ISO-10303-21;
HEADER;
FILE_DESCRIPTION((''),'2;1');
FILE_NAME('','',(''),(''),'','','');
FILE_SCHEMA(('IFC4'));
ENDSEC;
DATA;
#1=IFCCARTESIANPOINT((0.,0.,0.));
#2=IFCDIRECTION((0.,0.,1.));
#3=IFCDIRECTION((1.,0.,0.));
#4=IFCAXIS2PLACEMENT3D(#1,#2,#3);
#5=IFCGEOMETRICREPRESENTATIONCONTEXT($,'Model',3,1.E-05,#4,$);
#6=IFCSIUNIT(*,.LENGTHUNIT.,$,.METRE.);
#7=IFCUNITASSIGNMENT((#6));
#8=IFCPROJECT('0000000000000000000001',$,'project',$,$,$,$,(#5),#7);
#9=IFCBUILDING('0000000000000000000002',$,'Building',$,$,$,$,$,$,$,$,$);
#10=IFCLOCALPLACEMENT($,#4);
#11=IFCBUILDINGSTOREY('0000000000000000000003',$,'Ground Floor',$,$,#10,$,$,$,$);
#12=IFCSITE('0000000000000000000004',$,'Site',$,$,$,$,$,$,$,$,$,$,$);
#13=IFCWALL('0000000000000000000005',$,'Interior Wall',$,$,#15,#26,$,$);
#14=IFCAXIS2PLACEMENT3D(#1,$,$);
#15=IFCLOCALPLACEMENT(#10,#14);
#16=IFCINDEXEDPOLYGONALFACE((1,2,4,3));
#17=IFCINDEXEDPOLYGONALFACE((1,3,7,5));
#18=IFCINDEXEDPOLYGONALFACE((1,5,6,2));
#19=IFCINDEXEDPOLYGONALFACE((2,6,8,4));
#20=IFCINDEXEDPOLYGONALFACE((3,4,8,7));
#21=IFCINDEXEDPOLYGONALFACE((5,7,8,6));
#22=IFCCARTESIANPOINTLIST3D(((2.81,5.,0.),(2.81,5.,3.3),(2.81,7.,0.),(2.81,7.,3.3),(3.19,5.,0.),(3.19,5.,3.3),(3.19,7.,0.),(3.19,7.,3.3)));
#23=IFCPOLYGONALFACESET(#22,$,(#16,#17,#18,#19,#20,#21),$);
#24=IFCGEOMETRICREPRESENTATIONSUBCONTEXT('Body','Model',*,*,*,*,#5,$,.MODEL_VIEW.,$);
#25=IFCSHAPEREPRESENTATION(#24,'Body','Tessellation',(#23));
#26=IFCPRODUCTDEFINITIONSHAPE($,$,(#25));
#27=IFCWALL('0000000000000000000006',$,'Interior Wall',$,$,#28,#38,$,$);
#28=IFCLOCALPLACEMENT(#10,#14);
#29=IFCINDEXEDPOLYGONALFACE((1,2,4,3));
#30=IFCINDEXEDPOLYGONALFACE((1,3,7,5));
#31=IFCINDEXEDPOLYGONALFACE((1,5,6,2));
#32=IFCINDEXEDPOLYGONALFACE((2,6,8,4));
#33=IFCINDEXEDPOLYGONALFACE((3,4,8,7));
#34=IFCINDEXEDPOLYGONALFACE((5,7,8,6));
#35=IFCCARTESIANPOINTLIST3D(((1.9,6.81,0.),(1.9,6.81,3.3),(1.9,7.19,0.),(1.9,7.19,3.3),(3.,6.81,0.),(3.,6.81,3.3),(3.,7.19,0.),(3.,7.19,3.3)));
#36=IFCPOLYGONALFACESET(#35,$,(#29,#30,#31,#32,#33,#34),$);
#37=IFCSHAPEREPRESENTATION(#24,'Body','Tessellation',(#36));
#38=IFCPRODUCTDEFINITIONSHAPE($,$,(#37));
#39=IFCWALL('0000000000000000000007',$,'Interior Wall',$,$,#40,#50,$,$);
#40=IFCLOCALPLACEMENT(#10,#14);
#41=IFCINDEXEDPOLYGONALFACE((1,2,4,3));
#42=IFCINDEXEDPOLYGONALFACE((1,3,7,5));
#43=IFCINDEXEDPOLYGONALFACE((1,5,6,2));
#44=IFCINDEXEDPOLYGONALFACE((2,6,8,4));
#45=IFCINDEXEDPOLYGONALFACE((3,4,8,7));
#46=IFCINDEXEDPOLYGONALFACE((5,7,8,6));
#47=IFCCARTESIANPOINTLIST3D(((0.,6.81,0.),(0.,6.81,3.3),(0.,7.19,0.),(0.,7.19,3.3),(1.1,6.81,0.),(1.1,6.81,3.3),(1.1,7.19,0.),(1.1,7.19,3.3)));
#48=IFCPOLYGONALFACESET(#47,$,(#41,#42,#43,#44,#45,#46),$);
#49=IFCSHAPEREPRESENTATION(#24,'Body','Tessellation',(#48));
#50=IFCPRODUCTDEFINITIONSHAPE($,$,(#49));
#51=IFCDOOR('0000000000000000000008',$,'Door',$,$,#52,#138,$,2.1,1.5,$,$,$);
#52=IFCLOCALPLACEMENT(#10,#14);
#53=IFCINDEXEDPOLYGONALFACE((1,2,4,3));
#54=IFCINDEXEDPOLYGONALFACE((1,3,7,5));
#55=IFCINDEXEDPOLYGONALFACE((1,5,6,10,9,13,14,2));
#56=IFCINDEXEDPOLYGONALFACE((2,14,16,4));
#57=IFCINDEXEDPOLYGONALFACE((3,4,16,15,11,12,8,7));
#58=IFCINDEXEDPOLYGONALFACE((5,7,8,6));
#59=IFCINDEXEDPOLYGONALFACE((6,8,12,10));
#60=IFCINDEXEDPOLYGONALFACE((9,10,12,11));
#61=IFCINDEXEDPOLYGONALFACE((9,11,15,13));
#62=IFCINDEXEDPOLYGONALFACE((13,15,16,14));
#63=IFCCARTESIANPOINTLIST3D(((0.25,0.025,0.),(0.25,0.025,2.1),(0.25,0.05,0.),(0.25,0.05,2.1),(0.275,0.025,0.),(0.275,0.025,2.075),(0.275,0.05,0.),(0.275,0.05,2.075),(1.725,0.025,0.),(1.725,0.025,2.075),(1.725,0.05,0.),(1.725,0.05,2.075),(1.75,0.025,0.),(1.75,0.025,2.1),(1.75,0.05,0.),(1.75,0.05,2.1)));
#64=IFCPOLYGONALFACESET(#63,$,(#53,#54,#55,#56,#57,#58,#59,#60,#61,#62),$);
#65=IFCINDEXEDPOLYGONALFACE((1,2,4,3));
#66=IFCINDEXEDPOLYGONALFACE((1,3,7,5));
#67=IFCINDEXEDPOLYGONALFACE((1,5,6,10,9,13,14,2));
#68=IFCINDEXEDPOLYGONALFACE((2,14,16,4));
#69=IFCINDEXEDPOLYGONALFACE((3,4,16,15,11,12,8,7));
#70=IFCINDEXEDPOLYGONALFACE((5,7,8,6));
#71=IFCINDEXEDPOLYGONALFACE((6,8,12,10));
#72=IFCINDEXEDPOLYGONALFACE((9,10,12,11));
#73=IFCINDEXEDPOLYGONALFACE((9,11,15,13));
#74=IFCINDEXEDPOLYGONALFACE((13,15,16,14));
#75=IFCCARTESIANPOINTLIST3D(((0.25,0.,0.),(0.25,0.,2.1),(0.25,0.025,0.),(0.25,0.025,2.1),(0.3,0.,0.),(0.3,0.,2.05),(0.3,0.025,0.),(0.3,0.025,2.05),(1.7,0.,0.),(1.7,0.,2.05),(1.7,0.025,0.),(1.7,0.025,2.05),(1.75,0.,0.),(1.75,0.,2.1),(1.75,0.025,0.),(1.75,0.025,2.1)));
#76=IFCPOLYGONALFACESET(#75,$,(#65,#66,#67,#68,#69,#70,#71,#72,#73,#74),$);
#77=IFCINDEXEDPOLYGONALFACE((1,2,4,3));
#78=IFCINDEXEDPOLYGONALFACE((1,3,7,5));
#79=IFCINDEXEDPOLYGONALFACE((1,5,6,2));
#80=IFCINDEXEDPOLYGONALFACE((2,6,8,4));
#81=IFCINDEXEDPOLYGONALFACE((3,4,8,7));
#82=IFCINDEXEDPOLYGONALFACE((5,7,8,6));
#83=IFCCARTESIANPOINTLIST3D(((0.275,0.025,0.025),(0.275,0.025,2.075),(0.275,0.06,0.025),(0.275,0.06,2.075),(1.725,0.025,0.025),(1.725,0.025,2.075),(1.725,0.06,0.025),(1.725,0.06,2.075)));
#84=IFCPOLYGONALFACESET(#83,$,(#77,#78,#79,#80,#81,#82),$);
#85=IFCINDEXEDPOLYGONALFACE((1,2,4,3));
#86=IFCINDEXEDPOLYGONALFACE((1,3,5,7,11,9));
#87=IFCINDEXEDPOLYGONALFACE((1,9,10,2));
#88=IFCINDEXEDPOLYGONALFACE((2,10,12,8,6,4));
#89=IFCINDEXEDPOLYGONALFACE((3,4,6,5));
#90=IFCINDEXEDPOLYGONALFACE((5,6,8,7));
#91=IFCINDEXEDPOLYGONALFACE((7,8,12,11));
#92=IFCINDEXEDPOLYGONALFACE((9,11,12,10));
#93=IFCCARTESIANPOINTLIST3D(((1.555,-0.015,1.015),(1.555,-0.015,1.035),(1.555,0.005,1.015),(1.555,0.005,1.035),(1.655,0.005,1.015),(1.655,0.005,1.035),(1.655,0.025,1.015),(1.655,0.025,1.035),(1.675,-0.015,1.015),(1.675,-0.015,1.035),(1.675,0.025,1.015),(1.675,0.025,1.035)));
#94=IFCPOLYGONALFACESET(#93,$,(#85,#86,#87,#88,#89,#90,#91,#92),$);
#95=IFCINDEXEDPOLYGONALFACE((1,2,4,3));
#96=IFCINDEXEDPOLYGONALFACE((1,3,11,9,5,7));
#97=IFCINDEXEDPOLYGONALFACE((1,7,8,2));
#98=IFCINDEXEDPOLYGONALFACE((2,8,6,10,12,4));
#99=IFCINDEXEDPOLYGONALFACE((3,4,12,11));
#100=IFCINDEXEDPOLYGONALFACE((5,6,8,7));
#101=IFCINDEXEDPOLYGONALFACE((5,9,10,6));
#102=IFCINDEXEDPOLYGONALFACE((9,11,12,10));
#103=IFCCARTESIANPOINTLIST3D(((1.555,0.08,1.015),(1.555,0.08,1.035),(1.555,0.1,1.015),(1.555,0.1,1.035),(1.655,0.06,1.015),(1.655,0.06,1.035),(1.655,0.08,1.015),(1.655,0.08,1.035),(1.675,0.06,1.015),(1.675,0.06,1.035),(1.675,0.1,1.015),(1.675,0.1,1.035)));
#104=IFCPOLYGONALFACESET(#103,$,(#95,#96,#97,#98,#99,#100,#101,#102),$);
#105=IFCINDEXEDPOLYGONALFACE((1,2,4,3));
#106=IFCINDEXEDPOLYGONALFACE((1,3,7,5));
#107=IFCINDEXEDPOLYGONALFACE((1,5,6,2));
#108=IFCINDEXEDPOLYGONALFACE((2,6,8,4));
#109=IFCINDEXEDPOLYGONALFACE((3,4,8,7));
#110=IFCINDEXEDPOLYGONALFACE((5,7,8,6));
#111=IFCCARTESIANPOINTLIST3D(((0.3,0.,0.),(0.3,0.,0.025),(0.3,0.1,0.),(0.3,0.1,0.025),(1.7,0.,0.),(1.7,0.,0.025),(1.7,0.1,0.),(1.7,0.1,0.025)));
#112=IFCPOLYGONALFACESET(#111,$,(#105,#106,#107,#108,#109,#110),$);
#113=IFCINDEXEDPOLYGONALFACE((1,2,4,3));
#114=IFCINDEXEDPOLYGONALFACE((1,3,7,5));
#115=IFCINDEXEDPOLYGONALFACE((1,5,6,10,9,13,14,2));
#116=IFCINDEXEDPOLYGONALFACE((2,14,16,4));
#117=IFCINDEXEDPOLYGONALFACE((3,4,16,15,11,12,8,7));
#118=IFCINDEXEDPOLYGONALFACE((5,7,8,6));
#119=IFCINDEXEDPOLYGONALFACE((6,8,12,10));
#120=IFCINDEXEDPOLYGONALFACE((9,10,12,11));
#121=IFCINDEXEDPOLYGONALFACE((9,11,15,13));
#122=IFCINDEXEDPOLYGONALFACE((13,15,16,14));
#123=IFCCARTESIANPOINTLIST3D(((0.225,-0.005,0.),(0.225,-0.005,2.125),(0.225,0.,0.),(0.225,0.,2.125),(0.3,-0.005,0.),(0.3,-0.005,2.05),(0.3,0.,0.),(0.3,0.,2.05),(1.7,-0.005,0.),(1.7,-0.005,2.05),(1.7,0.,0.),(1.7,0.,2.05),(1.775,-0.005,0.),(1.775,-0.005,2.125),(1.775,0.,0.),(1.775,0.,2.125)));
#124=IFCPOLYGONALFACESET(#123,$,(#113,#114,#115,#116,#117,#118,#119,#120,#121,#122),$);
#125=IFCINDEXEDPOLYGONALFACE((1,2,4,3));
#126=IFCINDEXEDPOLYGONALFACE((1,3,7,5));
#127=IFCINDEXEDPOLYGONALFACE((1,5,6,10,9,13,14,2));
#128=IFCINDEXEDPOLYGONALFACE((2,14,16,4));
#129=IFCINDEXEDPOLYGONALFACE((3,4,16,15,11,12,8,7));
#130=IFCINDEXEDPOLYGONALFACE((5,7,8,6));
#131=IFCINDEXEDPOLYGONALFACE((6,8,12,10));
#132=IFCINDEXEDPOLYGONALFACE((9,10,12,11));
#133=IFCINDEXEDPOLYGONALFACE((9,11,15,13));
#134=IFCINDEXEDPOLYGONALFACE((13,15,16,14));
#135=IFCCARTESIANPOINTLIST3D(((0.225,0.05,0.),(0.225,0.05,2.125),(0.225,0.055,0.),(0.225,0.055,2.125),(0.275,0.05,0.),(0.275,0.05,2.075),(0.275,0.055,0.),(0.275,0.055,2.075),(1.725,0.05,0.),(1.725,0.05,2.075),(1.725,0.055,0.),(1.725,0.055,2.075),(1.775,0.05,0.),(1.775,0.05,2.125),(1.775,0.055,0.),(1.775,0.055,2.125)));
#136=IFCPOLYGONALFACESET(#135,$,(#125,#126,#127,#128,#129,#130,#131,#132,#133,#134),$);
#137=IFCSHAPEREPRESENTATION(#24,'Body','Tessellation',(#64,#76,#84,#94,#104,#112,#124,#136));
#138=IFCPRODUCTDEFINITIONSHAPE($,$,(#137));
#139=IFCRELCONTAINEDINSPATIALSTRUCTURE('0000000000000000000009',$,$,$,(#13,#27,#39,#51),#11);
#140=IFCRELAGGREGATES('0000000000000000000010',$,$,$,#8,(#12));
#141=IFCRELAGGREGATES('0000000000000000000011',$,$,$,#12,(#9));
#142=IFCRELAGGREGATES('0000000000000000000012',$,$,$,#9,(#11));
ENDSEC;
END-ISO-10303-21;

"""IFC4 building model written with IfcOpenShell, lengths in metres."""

from ifc_helpers import new_model, si_unit, frame, origin_with_axes, place, context, subcontext, project, spatial, line, indexed_curve, outline, extrude, element, save


model = new_model("IFC4")

# Units and contexts
model_context = context("Model", 3, precision=1e-05, world=origin_with_axes())
body_context = subcontext(model_context, "Body", "Model", "MODEL_VIEW")
ifc_project = project(units=[si_unit("LENGTHUNIT", "METRE")], contexts=[model_context])

# Site, building, storey
site = spatial("IfcSite", under=ifc_project, Name="Site")
building = spatial("IfcBuilding", under=site, Name="Building")
storey_placement = place(None, origin_with_axes())
storey = spatial("IfcBuildingStorey", under=building, at=storey_placement, Name="Ground Floor")

# Walls
wall_1_placement = place(storey_placement, frame((3.0, 7.0, 0.0), z_axis=(0.0, 0.0, 1.0), x_axis=(0.0, -1.0, 0.0)))
element("IfcWall", 1, at=wall_1_placement, inside=storey, Name="Interior Wall", context=body_context, shape_type="SweptSolid", body=[
    extrude(outline(indexed_curve([(0.0, 0.0), (0.0, 0.38), (2.0, 0.38), (2.0, 0.0), (0.0, 0.0)], self_intersect=False)), frame((0.0, -0.19, 0.0), z_axis=(0.0, 0.0, 1.0), x_axis=(1.0, 0.0, 0.0)), (0.0, 0.0, 1.0), 3.3),
])
for number, where, z_axis, x_axis, name in (
    (2, (3.0, 7.0, 0.0), (0.0, 0.0, 1.0), (-1.0, 0.0, 0.0), "Interior Wall"),
    (3, (1.1, 7.0, 0.0), (0.0, 0.0, 1.0), (-1.0, 0.0, 0.0), "Interior Wall"),
):
    element("IfcWall", number, at=place(storey_placement, frame(where, z_axis=z_axis, x_axis=x_axis)), inside=storey, Name=name, context=body_context, shape_type="SweptSolid", body=[
        extrude(outline(indexed_curve([(0.0, 0.0), (0.0, 0.38), (1.1, 0.38), (1.1, 0.0), (0.0, 0.0)], self_intersect=False)), frame((0.0, -0.19, 0.0), z_axis=(0.0, 0.0, 1.0), x_axis=(1.0, 0.0, 0.0)), (0.0, 0.0, 1.0), 3.3),
    ])

# Door
door_1_placement = place(storey_placement, frame((0.25, 0.0, 0.0), z_axis=(0.0, 0.0, 1.0), x_axis=(1.0, 0.0, 0.0)))
element("IfcDoor", 4, at=door_1_placement, inside=storey, Name="Door", OverallHeight=2.1, OverallWidth=1.5, context=body_context, shape_type="SweptSolid", body=[
    extrude(outline(indexed_curve([(0.0, 0.0), (0.0, 2.1), (1.5, 2.1), (1.5, 0.0), (1.475, 0.0), (1.475, 2.075), (0.025, 2.075), (0.025, 0.0)], segments=[line(1, 2, 3, 4, 5, 6, 7, 8, 1)])), frame((0.0, 0.025, 0.0), z_axis=(0.0, -1.0, 0.0), x_axis=(1.0, 0.0, 0.0)), (0.0, 0.0, -1.0), 0.025),
    extrude(outline(indexed_curve([(0.0, 0.0), (0.0, 2.1), (1.5, 2.1), (1.5, 0.0), (1.45, 0.0), (1.45, 2.05), (0.05, 2.05), (0.05, 0.0)], segments=[line(1, 2, 3, 4, 5, 6, 7, 8, 1)])), frame((0.0, 0.0, 0.0), z_axis=(0.0, -1.0, 0.0), x_axis=(1.0, 0.0, 0.0)), (0.0, 0.0, -1.0), 0.025),
    extrude(outline(indexed_curve([(0.0, 0.0), (1.45, 0.0), (1.45, 0.035), (0.0, 0.035)], segments=[line(1, 2, 3, 4, 1)])), frame((0.025, 0.025, 0.025), z_axis=(0.0, 0.0, 1.0), x_axis=(1.0, 0.0, 0.0)), (0.0, 0.0, 1.0), 2.05),
    extrude(outline(indexed_curve([(0.0, 0.0), (0.0, -0.04), (-0.12, -0.04), (-0.12, -0.02), (-0.02, -0.02), (-0.02, 0.0)], segments=[line(1, 2, 3, 4, 5, 6, 1)])), frame((1.425, 0.025, 1.015), z_axis=(0.0, 0.0, 1.0), x_axis=(1.0, 0.0, 0.0)), (0.0, 0.0, 1.0), 0.02),
    extrude(outline(indexed_curve([(0.0, 0.0), (0.0, 0.04), (-0.12, 0.04), (-0.12, 0.02), (-0.02, 0.02), (-0.02, 0.0)], segments=[line(1, 2, 3, 4, 5, 6, 1)])), frame((1.425, 0.06, 1.015), z_axis=(0.0, 0.0, 1.0), x_axis=(1.0, 0.0, 0.0)), (0.0, 0.0, 1.0), 0.02),
    extrude(outline(indexed_curve([(0.0, 0.0), (1.4, 0.0), (1.4, 0.1), (0.0, 0.1)], segments=[line(1, 2, 3, 4, 1)])), frame((0.05, 0.0, 0.0), z_axis=(0.0, 0.0, 1.0), x_axis=(1.0, 0.0, 0.0)), (0.0, 0.0, 1.0), 0.025),
    extrude(outline(indexed_curve([(0.0, 0.0), (0.0, 2.125), (1.55, 2.125), (1.55, 0.0), (1.475, 0.0), (1.475, 2.05), (0.075, 2.05), (0.075, 0.0)], segments=[line(1, 2, 3, 4, 5, 6, 7, 8, 1)])), frame((-0.025, -0.005, 0.0), z_axis=(0.0, -1.0, 0.0), x_axis=(1.0, 0.0, 0.0)), (0.0, 0.0, -1.0), 0.005),
    extrude(outline(indexed_curve([(0.0, 0.0), (0.0, 2.125), (1.55, 2.125), (1.55, 0.0), (1.5, 0.0), (1.5, 2.075), (0.05, 2.075), (0.05, 0.0)], segments=[line(1, 2, 3, 4, 5, 6, 7, 8, 1)])), frame((-0.025, 0.05, 0.0), z_axis=(0.0, -1.0, 0.0), x_axis=(1.0, 0.0, 0.0)), (0.0, 0.0, -1.0), 0.005),
])

save(model, "model.ifc")
